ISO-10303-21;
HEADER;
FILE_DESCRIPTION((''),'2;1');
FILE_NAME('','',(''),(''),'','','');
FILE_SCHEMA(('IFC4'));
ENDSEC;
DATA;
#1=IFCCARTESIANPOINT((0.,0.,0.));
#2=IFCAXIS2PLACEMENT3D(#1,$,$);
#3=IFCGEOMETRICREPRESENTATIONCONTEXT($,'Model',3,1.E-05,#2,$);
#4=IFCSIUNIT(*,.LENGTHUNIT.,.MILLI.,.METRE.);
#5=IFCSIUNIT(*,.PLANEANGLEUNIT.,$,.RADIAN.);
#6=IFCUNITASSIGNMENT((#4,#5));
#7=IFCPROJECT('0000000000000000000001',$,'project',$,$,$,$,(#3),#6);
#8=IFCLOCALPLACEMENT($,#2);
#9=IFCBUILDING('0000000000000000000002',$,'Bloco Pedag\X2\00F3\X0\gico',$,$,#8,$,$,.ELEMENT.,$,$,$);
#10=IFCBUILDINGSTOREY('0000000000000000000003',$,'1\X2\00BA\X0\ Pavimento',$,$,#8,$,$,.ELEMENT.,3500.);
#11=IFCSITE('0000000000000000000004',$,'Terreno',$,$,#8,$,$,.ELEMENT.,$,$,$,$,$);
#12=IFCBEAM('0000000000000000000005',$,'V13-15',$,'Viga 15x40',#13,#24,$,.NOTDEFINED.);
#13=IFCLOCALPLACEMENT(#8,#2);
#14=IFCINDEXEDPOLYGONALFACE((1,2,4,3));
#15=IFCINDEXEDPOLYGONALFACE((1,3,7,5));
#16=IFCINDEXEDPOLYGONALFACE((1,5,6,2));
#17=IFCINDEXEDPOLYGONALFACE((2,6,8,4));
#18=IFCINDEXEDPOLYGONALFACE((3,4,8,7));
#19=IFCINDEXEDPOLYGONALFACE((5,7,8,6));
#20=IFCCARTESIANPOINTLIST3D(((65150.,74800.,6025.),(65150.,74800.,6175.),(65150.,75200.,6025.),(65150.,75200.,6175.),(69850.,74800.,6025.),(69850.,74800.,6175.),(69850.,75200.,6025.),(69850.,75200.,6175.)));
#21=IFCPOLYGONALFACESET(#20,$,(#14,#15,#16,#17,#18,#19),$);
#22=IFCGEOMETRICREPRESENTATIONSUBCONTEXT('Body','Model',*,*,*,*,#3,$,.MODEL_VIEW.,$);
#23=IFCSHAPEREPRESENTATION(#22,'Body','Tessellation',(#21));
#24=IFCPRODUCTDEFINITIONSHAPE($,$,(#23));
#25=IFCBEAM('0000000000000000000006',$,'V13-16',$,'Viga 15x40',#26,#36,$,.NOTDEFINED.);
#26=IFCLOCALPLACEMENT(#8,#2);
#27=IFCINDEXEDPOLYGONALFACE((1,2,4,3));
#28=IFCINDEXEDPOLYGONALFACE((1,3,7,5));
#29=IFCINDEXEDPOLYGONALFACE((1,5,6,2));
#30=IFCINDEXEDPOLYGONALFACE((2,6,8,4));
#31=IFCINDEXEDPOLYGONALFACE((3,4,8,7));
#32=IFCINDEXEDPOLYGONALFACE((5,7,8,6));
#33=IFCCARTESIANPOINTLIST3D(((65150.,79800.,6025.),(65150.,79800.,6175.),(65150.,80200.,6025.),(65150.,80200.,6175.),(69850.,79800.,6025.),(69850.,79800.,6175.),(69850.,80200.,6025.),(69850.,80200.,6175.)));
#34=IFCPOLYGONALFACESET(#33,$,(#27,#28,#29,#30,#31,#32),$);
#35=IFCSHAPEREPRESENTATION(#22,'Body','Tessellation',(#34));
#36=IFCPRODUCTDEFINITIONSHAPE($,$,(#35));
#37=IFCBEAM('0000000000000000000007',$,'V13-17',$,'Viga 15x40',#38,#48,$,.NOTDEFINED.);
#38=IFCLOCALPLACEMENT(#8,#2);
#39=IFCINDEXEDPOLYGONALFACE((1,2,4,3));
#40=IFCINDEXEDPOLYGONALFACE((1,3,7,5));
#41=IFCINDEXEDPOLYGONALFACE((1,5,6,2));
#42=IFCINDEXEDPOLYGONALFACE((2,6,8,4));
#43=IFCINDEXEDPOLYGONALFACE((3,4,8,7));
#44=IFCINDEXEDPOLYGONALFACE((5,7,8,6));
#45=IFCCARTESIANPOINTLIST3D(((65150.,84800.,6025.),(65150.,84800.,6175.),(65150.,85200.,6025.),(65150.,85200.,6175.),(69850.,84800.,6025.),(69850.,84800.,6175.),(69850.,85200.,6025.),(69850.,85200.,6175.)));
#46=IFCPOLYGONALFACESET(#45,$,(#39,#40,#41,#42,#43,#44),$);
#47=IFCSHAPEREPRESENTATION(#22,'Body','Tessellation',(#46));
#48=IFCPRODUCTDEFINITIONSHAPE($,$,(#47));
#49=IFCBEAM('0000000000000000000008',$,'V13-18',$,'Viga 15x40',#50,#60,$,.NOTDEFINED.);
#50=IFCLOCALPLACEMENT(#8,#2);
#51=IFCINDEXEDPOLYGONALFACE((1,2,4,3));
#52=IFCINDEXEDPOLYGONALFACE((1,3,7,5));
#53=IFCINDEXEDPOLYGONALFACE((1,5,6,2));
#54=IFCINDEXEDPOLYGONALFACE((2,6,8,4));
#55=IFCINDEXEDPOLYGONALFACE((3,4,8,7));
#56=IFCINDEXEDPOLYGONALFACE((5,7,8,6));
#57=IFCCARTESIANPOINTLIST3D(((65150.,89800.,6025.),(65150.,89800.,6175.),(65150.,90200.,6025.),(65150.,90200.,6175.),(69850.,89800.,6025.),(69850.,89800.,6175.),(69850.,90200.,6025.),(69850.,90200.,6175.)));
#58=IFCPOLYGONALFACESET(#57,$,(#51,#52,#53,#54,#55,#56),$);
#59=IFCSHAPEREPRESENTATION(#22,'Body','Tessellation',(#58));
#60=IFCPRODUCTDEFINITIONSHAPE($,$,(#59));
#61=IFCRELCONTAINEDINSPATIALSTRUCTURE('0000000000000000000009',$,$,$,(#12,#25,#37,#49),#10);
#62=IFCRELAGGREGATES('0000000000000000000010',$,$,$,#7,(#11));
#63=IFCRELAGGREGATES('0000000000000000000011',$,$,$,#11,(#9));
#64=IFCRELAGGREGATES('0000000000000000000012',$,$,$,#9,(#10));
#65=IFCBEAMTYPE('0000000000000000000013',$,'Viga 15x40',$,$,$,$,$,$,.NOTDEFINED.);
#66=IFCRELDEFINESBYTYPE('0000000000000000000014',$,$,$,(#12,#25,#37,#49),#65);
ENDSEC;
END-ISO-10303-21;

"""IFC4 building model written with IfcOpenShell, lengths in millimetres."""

from ifc_helpers import new_model, si_unit, frame, origin, origin_2d, place, context, subcontext, project, spatial, rectangle, extrude, type_object, element, save


model = new_model("IFC4")

# Units and contexts
model_context = context("Model", 3, precision=1e-05, world=origin())
body_context = subcontext(model_context, "Body", "Model", "MODEL_VIEW")
ifc_project = project(units=[si_unit("LENGTHUNIT", "METRE", prefix="MILLI"), si_unit("PLANEANGLEUNIT", "RADIAN")], contexts=[model_context])

# Site, building, storey
placement = place(None, origin())
site = spatial("IfcSite", under=ifc_project, at=placement, Name="Terreno", CompositionType="ELEMENT")
building = spatial("IfcBuilding", under=site, at=placement, Name="Bloco Pedagógico", CompositionType="ELEMENT")
storey = spatial("IfcBuildingStorey", under=building, at=placement, Name="1º Pavimento", CompositionType="ELEMENT", Elevation=3500.0)

# Beams
beam_type = type_object("IfcBeamType", Name="Viga 15x40", PredefinedType="NOTDEFINED")
for number, where, z_axis, x_axis, name in (
    (1, (65150.0, 75000.0, 6100.0), (1.0, 0.0, 0.0), (0.0, 1.0, 0.0), "V13-15"),
    (2, (65150.0, 80000.0, 6100.0), (1.0, 0.0, 0.0), (0.0, 1.0, 0.0), "V13-16"),
    (3, (65150.0, 85000.0, 6100.0), (1.0, 0.0, 0.0), (0.0, 1.0, 0.0), "V13-17"),
    (4, (65150.0, 90000.0, 6100.0), (1.0, 0.0, 0.0), (0.0, 1.0, 0.0), "V13-18"),
):
    element("IfcBeam", number, at=place(None, frame(where, z_axis=z_axis, x_axis=x_axis)), inside=storey, type_object=beam_type, Name=name, ObjectType="Viga 15x40", PredefinedType="NOTDEFINED", context=body_context, shape_type="SweptSolid", body=[
        extrude(rectangle(XDim=400.0, YDim=150.0, at=origin_2d()), None, (0.0, 0.0, 1.0), 4700.0),
    ])

save(model, "model.ifc")
